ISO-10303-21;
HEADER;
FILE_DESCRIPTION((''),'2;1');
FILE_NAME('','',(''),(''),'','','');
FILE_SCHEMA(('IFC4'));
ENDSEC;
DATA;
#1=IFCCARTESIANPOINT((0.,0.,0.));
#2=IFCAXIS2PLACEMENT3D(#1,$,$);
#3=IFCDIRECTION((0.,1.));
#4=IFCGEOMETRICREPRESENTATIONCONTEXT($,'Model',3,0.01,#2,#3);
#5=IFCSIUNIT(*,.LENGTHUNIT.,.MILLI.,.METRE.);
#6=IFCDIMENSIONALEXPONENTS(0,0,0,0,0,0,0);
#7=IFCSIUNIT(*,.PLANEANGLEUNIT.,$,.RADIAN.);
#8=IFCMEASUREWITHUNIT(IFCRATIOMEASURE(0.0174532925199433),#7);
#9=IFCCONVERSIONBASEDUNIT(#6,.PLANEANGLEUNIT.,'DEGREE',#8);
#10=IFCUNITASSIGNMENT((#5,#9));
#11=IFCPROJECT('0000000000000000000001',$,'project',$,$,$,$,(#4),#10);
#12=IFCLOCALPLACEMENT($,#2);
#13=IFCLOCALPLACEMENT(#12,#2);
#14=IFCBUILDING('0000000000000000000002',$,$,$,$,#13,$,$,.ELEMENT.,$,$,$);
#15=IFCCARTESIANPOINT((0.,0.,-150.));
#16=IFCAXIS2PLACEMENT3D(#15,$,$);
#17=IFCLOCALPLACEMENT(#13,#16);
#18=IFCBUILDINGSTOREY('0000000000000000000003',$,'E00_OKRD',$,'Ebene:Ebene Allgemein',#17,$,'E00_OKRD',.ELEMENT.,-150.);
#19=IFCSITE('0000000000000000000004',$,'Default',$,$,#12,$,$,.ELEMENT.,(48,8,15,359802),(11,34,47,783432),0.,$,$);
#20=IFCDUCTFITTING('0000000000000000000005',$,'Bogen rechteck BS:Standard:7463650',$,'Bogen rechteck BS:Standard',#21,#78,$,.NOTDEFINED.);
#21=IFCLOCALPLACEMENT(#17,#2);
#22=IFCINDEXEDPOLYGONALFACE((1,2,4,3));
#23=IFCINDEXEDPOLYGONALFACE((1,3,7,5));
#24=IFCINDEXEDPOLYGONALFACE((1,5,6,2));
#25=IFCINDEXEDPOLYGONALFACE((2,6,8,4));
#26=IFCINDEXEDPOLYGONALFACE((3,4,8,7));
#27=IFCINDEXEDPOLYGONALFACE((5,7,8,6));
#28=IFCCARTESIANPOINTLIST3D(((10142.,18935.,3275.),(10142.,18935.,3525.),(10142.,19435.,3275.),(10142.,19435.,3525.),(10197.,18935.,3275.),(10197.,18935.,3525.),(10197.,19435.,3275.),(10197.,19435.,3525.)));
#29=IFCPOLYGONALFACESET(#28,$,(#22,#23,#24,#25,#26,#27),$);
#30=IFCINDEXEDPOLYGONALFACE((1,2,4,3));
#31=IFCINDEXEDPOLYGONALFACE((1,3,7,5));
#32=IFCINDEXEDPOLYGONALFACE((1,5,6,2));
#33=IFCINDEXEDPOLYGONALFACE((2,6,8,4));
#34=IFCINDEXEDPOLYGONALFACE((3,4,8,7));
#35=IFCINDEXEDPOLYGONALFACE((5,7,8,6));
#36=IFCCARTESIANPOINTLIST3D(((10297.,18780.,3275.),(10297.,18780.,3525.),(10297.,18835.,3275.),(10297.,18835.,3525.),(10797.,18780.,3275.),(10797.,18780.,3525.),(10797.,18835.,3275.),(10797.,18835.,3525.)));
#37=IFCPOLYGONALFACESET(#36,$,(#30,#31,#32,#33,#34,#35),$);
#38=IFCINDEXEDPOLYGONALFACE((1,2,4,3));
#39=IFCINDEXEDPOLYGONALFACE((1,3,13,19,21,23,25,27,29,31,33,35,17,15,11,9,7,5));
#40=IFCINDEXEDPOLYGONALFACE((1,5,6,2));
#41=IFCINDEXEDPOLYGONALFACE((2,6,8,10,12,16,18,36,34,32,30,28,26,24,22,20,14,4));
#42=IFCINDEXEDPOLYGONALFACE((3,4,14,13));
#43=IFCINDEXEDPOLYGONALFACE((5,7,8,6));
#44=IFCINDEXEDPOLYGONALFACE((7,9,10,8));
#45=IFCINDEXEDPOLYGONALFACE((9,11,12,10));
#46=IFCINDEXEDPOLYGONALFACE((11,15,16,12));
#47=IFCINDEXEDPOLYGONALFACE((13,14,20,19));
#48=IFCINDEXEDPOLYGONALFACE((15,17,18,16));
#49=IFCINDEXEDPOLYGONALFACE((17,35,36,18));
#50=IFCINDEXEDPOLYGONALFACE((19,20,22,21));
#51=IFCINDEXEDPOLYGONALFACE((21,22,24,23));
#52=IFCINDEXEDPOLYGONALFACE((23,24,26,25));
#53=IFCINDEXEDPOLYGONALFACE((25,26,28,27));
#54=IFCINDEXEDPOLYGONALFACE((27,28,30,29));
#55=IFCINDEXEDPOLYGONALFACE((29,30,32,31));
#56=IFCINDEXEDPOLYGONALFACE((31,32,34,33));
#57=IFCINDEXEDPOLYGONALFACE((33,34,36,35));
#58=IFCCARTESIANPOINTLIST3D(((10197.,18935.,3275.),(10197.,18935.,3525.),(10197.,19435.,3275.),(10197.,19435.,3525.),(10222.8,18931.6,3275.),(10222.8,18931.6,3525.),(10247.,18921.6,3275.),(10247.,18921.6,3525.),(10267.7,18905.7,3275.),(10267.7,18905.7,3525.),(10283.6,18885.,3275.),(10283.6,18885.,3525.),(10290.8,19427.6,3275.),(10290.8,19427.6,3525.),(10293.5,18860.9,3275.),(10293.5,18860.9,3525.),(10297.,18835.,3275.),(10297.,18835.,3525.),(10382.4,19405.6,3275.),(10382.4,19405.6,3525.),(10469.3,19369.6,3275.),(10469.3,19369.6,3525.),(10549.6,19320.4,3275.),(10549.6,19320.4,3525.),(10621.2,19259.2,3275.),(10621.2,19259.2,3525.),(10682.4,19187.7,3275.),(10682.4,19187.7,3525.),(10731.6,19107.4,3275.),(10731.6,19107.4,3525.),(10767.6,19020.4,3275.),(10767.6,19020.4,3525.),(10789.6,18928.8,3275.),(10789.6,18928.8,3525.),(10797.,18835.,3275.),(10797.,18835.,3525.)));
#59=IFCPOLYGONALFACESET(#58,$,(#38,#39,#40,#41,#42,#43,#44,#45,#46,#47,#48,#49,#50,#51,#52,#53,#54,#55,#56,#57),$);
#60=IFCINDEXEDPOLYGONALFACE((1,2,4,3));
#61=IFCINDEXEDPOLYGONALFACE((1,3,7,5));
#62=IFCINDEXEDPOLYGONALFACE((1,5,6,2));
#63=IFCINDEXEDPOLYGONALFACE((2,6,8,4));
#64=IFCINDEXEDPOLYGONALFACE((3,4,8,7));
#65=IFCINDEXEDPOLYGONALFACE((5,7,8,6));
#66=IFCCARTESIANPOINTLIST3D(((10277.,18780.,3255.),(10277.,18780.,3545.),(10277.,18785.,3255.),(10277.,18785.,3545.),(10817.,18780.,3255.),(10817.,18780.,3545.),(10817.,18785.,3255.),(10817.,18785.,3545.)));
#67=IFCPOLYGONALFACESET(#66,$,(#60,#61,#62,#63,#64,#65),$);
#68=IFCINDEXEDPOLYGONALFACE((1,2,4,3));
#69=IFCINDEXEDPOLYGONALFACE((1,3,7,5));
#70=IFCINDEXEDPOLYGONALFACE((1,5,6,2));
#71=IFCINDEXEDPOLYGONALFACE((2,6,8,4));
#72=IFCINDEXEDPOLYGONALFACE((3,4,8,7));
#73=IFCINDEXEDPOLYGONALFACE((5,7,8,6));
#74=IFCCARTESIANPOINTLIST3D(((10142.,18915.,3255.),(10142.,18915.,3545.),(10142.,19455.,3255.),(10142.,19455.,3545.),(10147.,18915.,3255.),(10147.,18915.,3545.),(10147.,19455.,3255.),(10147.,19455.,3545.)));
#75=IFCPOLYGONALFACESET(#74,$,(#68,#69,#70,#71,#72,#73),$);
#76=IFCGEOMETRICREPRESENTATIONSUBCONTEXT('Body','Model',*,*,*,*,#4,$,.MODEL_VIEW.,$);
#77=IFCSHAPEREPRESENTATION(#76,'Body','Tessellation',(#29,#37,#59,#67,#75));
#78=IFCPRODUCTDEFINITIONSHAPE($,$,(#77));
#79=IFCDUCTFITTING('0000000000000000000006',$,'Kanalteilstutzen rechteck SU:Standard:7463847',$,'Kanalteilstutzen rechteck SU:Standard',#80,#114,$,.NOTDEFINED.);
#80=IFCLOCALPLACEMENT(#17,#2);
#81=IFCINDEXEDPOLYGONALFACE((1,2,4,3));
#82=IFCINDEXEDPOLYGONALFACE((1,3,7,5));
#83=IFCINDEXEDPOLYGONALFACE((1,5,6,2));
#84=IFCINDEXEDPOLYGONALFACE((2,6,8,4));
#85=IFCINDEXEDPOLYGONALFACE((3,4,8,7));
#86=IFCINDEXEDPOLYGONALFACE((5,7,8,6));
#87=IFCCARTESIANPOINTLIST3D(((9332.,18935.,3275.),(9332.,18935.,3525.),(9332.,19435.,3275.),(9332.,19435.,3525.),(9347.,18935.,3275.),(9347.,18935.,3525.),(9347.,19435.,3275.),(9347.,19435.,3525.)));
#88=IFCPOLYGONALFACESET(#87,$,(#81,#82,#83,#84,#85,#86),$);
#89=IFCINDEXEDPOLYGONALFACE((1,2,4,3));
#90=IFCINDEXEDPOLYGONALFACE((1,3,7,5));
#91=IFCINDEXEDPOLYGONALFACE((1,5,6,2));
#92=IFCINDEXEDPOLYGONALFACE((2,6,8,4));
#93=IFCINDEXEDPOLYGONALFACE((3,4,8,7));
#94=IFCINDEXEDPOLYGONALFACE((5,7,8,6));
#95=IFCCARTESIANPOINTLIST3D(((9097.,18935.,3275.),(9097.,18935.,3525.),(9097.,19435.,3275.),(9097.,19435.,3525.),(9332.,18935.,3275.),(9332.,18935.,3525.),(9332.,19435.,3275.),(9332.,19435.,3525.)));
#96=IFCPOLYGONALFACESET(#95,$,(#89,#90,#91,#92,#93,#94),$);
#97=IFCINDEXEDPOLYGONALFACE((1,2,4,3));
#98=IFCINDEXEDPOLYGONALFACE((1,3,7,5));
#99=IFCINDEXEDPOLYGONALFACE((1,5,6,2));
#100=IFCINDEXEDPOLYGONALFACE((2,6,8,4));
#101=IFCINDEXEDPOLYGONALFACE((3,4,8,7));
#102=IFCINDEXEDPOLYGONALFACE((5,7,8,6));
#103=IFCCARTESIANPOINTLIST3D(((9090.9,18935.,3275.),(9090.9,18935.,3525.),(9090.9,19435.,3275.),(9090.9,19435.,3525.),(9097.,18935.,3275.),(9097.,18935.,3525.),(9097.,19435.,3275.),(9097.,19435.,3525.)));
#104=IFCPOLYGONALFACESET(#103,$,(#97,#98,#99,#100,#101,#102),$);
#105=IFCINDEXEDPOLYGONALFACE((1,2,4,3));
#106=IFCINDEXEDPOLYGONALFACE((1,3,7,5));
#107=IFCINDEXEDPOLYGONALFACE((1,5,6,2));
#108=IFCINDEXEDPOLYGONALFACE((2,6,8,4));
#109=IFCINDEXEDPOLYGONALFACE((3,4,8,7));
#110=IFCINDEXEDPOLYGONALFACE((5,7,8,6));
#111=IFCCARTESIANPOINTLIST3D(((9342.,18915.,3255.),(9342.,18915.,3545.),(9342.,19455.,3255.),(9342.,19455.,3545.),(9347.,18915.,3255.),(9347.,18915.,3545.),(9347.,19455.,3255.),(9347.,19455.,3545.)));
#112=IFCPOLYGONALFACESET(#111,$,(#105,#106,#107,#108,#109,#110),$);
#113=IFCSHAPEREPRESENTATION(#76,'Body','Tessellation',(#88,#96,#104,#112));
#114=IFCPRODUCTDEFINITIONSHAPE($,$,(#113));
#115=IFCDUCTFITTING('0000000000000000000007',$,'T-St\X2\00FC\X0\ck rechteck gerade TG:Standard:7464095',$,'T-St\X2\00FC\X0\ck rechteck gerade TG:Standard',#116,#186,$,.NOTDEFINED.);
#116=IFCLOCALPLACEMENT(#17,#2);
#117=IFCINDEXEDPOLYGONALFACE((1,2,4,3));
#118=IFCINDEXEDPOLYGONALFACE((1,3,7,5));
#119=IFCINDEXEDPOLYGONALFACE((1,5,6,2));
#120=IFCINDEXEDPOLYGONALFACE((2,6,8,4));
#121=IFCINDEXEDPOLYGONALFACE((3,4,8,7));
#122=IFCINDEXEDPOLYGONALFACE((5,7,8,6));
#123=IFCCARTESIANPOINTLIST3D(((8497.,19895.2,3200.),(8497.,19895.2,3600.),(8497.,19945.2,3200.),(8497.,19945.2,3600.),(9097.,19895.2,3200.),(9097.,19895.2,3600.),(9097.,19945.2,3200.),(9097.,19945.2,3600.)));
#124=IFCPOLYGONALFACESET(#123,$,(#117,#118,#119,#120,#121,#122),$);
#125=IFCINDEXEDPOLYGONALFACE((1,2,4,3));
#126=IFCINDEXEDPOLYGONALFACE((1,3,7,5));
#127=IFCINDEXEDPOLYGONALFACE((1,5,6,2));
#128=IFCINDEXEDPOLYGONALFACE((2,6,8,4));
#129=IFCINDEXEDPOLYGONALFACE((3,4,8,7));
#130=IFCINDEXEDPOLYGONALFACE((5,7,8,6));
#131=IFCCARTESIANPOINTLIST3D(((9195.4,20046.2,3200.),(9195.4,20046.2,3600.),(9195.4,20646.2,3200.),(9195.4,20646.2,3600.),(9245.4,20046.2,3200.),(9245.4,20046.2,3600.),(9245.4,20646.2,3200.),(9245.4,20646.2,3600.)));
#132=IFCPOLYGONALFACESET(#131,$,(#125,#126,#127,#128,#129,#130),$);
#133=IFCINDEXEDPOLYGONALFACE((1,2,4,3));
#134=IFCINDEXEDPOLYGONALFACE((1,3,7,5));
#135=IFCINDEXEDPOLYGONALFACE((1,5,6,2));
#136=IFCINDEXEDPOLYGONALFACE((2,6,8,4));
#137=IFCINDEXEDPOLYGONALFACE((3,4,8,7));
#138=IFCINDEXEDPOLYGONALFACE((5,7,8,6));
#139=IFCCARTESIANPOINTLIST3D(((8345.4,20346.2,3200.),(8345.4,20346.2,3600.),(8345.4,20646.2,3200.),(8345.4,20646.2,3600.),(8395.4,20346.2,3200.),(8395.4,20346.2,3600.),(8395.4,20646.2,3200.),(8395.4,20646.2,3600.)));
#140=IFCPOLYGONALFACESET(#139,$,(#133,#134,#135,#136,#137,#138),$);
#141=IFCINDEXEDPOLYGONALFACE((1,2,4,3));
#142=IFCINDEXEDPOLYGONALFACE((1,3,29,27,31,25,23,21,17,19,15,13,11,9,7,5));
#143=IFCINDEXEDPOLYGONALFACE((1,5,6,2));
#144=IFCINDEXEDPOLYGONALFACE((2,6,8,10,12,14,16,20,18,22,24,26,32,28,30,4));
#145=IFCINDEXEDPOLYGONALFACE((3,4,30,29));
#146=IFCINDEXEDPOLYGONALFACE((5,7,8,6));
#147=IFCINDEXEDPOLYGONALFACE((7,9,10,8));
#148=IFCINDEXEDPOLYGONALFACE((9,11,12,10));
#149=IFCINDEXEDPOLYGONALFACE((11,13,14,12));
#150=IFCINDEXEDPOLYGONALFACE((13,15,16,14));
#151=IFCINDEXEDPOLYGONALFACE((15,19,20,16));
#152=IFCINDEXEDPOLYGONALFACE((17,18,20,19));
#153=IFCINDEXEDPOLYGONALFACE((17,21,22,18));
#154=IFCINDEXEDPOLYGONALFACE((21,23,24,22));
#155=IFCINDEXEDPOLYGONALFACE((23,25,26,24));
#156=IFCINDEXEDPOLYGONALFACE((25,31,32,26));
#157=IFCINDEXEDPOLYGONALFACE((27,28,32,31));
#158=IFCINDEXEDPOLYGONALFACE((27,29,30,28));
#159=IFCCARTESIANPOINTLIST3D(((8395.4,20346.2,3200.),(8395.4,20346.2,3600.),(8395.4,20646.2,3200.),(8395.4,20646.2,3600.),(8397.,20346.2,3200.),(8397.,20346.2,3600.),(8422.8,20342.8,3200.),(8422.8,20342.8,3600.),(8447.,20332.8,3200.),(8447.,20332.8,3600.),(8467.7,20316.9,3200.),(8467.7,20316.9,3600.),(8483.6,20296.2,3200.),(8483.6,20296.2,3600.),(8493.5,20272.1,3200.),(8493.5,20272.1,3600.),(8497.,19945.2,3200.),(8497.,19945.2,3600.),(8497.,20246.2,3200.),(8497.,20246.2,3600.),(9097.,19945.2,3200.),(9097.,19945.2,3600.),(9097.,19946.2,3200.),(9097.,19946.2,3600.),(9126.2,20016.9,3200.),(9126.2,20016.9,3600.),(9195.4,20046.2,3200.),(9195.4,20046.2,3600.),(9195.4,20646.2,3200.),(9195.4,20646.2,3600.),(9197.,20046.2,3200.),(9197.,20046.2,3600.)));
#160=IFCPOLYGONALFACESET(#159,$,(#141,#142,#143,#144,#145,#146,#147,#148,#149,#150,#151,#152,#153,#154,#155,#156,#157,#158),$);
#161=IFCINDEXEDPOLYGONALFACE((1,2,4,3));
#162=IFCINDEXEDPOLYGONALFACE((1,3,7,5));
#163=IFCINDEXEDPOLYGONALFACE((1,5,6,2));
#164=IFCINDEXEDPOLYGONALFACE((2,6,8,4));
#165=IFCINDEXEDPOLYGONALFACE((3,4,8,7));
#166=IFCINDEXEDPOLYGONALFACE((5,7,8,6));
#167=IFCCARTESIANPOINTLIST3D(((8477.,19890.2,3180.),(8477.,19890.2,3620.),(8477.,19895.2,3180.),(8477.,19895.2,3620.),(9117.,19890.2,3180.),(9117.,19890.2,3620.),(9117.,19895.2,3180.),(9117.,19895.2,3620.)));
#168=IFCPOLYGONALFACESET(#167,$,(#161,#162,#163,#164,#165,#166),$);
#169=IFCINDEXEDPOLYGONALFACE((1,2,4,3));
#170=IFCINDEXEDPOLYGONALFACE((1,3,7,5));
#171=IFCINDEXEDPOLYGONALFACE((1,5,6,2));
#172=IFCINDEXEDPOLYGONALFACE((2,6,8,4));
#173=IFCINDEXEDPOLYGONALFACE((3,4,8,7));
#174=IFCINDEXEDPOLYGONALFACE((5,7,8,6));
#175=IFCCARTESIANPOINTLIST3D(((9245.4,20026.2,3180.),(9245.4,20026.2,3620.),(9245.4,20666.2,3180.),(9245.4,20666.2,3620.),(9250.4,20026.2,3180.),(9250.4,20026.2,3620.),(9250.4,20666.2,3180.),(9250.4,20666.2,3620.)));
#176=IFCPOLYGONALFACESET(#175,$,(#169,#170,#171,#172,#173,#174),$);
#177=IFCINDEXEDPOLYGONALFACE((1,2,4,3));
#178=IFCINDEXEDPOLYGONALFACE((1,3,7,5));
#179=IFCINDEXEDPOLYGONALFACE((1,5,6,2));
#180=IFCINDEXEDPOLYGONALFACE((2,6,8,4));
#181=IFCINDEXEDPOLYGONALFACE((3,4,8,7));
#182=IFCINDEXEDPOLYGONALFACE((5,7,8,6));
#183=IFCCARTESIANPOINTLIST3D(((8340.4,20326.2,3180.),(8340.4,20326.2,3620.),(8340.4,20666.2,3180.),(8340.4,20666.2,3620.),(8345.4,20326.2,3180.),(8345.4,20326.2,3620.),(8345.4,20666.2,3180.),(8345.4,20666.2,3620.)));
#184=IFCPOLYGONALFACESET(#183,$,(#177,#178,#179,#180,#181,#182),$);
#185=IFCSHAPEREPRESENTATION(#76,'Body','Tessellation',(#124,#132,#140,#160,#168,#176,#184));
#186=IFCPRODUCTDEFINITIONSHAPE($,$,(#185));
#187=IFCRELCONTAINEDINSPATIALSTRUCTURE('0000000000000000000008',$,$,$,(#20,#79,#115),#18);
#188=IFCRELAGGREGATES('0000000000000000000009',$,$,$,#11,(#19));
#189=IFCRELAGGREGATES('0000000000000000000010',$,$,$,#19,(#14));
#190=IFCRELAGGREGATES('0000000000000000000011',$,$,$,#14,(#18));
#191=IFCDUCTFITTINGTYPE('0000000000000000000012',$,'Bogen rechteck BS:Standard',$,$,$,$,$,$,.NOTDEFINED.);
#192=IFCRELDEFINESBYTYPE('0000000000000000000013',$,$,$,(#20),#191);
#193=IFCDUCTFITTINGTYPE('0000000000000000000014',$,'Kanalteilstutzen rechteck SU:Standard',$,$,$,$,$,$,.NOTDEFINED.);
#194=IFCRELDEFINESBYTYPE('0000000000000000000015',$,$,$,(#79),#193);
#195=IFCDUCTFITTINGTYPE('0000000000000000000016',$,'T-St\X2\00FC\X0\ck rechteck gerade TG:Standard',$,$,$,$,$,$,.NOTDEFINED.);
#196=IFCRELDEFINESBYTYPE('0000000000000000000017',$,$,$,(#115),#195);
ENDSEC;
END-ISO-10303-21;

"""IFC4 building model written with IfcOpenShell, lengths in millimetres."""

from ifc_helpers import new_model, entity, si_unit, converted_unit, direction, frame, frame_2d, origin, origin_2d_with_axis, place, context, subcontext, project, spatial, polyline, circle_curve, parameter, trimmed, segment, composite_curve, rectangle, outline, extrude, source, transform, mapped, type_object, type_shapes, element, save


model = new_model("IFC4")

# Units and contexts
model_context = context("Model", 3, precision=0.01, world=origin(), true_north=direction((0.0, 1.0)))
body_context = subcontext(model_context, "Body", "Model", "MODEL_VIEW")
ifc_project = project(units=[si_unit("LENGTHUNIT", "METRE", prefix="MILLI"), converted_unit("PLANEANGLEUNIT", "DEGREE", entity("IfcRatioMeasure", 0.0174532925199433), si_unit("PLANEANGLEUNIT", "RADIAN"), dimensions=[0, 0, 0, 0, 0, 0, 0])], contexts=[model_context])

# Site, building, storey
site_placement = place(None, origin())
site = spatial("IfcSite", under=ifc_project, at=site_placement, Name="Default", CompositionType="ELEMENT", RefLatitude=(48, 8, 15, 359802), RefLongitude=(11, 34, 47, 783432), RefElevation=0.0)
building_placement = place(site_placement, origin())
building = spatial("IfcBuilding", under=site, at=building_placement, CompositionType="ELEMENT")
storey_placement = place(building_placement, frame((0.0, 0.0, -150.0)))
storey = spatial("IfcBuildingStorey", under=building, at=storey_placement, Name="E00_OKRD", ObjectType="Ebene:Ebene Allgemein", LongName="E00_OKRD", CompositionType="ELEMENT", Elevation=-150.0)

# Duct fittings
duct_fitting_type_1 = type_object("IfcDuctFittingType", Name="Bogen rechteck BS:Standard", PredefinedType="NOTDEFINED")
shared_shape_1 = source(origin(), body_context, "Body", "SweptSolid", [
    extrude(rectangle(XDim=55.0, YDim=500.0, at=frame_2d((0.0, 0.0), x_axis=(1.0, 0.0))), frame((0.0, 377.5, -125.0), z_axis=(0.0, 0.0, 1.0), x_axis=(0.0, 1.0, 0.0)), (0.0, 0.0, 1.0), 250.0),
    extrude(rectangle(XDim=500.0, YDim=55.0, at=frame_2d((0.0, 0.0), x_axis=(1.0, 0.0))), frame((-377.5, 0.0, -125.0), z_axis=(0.0, 0.0, 1.0), x_axis=(0.0, -1.0, 0.0)), (0.0, 0.0, 1.0), 250.0),
    extrude(outline(composite_curve([segment(polyline([(-425.0, -175.0), (75.0, -175.0)]), True, "CONTINUOUS"), segment(trimmed(circle_curve(frame_2d((175.0, -175.0), x_axis=(0.0, 1.0)), 100.0), [parameter(0.0)], [parameter(90.0)], True, "PARAMETER"), False, "CONTINUOUS"), segment(polyline([(175.0, -75.0), (175.0, 425.0)]), True, "CONTINUOUS"), segment(trimmed(circle_curve(frame_2d((175.0, -175.0), x_axis=(0.0, 1.0)), 600.0), [parameter(0.0)], [parameter(90.0)], True, "PARAMETER"), True, "CONTINUOUS")], self_intersect=False)), frame((-175.0, 175.0, -125.0), z_axis=(0.0, 0.0, 1.0), x_axis=(-1.0, 0.0, 0.0)), (0.0, 0.0, 1.0), 250.0),
    extrude(rectangle(XDim=5.0, YDim=540.0, at=frame_2d((0.0, 0.0), x_axis=(1.0, 0.0))), frame((-402.5, 0.0, -145.0)), (0.0, 0.0, 1.0), 290.0),
    extrude(rectangle(XDim=5.0, YDim=540.0, at=origin_2d_with_axis()), frame((0.0, 402.5, -145.0), z_axis=(0.0, 0.0, 1.0), x_axis=(0.0, 1.0, 0.0)), (0.0, 0.0, 1.0), 290.0),
])
type_shapes(duct_fitting_type_1, [shared_shape_1])
duct_fitting_1_placement = place(storey_placement, frame((10547.0, 19185.0, 3400.0), z_axis=(0.0, 0.0, 1.0), x_axis=(0.0, 1.0, 0.0)))
element("IfcDuctFitting", 1, at=duct_fitting_1_placement, inside=storey, type_object=duct_fitting_type_1, Name="Bogen rechteck BS:Standard:7463650", ObjectType="Bogen rechteck BS:Standard", PredefinedType="NOTDEFINED", context=body_context, shape_type="MappedRepresentation", body=[
    mapped(shared_shape_1, transform((0.0, 0.0, 0.0), scale=1.0)),
])
duct_fitting_type_2 = type_object("IfcDuctFittingType", Name="Kanalteilstutzen rechteck SU:Standard", PredefinedType="NOTDEFINED")
shared_shape_2 = source(origin(), body_context, "Body", "SweptSolid", [
    extrude(rectangle(XDim=15.0, YDim=500.0, at=frame_2d((0.0, 0.0), x_axis=(1.0, 0.0))), frame((242.5, 0.0, -125.0)), (0.0, 0.0, 1.0), 250.0),
    extrude(rectangle(XDim=235.0, YDim=500.0, at=frame_2d((0.0, 0.0), x_axis=(1.0, 0.0))), frame((117.5, 0.0, -125.0)), (0.0, 0.0, 1.0), 250.0),
    extrude(rectangle(XDim=6.1, YDim=500.0, at=frame_2d((0.0, 0.0), x_axis=(1.0, 0.0))), frame((-3.0, 0.0, -125.0)), (0.0, 0.0, 1.0), 250.0),
    extrude(rectangle(XDim=5.0, YDim=540.0, at=frame_2d((0.0, 0.0), x_axis=(1.0, 0.0))), frame((247.5, 0.0, -145.0)), (0.0, 0.0, 1.0), 290.0),
])
type_shapes(duct_fitting_type_2, [shared_shape_2])
duct_fitting_2_placement = place(storey_placement, frame((9097.0, 19185.0, 3400.0), z_axis=(0.0, 0.0, -1.0), x_axis=(1.0, 0.0, 0.0)))
element("IfcDuctFitting", 2, at=duct_fitting_2_placement, inside=storey, type_object=duct_fitting_type_2, Name="Kanalteilstutzen rechteck SU:Standard:7463847", ObjectType="Kanalteilstutzen rechteck SU:Standard", PredefinedType="NOTDEFINED", context=body_context, shape_type="MappedRepresentation", body=[
    mapped(shared_shape_2, transform((0.0, 0.0, 0.0), scale=1.0)),
])
duct_fitting_type_3 = type_object("IfcDuctFittingType", Name="T-Stück rechteck gerade TG:Standard", PredefinedType="NOTDEFINED")
shared_shape_3 = source(origin(), body_context, "Body", "SweptSolid", [
    extrude(rectangle(XDim=50.0, YDim=600.0, at=frame_2d((0.0, 0.0), x_axis=(1.0, 0.0))), frame((0.0, -501.0, -200.0), z_axis=(0.0, 0.0, 1.0), x_axis=(0.0, -1.0, 0.0)), (0.0, 0.0, 1.0), 400.0),
    extrude(rectangle(XDim=50.0, YDim=600.0, at=frame_2d((0.0, 0.0), x_axis=(1.0, 0.0))), frame((423.4, -75.0, -200.0), z_axis=(0.0, 0.0, 1.0), x_axis=(-1.0, 0.0, 0.0)), (0.0, 0.0, 1.0), 400.0),
    extrude(rectangle(XDim=50.0, YDim=300.0, at=origin_2d_with_axis()), frame((-426.6, 75.0, -200.0)), (0.0, 0.0, 1.0), 400.0),
    extrude(outline(composite_curve([segment(trimmed(circle_curve(frame_2d((-400.6, -269.8), x_axis=(-1.0, 0.0)), 100.0), [parameter(180.0)], [parameter(270.0)], True, "PARAMETER"), False, "CONTINUOUS"), segment(polyline([(-300.6, -269.8), (-300.6, -270.8)]), True, "CONTINUOUS"), segment(polyline([(-300.6, -270.8), (299.4, -270.8)]), True, "CONTINUOUS"), segment(polyline([(299.4, -270.8), (299.4, 30.2)]), True, "CONTINUOUS"), segment(trimmed(circle_curve(frame_2d((399.4, 30.2), x_axis=(-1.0, 0.0)), 100.0), [parameter(270.0)], [parameter(0.0)], True, "PARAMETER"), False, "CONTINUOUS"), segment(polyline([(399.4, 130.2), (401.0, 130.2)]), True, "CONTINUOUS"), segment(polyline([(401.0, 130.2), (401.0, 430.2)]), True, "CONTINUOUS"), segment(polyline([(401.0, 430.2), (-399.0, 430.2)]), True, "CONTINUOUS"), segment(polyline([(-399.0, 430.2), (-399.0, -169.8)]), True, "CONTINUOUS"), segment(polyline([(-399.0, -169.8), (-400.6, -169.8)]), True, "CONTINUOUS")], self_intersect=False)), frame((-0.6, -205.2, -200.0), z_axis=(0.0, 0.0, -1.0), x_axis=(-1.0, 0.0, 0.0)), (0.0, 0.0, -1.0), 400.0),
    extrude(rectangle(XDim=5.0, YDim=640.0, at=origin_2d_with_axis()), frame((0.0, -528.5, -220.0), z_axis=(0.0, 0.0, 1.0), x_axis=(0.0, 1.0, 0.0)), (0.0, 0.0, 1.0), 440.0),
    extrude(rectangle(XDim=5.0, YDim=640.0, at=origin_2d_with_axis()), frame((450.9, -75.0, -220.0), z_axis=(0.0, 0.0, 1.0), x_axis=(-1.0, 0.0, 0.0)), (0.0, 0.0, 1.0), 440.0),
    extrude(rectangle(XDim=5.0, YDim=340.0, at=frame_2d((0.0, 0.0), x_axis=(1.0, 0.0))), frame((-454.1, 75.0, -220.0), z_axis=(0.0, 0.0, 1.0), x_axis=(-1.0, 0.0, 0.0)), (0.0, 0.0, 1.0), 440.0),
])
type_shapes(duct_fitting_type_3, [shared_shape_3])
duct_fitting_3_placement = place(storey_placement, frame((8797.0, 20421.2, 3400.0)))
element("IfcDuctFitting", 3, at=duct_fitting_3_placement, inside=storey, type_object=duct_fitting_type_3, Name="T-Stück rechteck gerade TG:Standard:7464095", ObjectType="T-Stück rechteck gerade TG:Standard", PredefinedType="NOTDEFINED", context=body_context, shape_type="MappedRepresentation", body=[
    mapped(shared_shape_3, transform((0.0, 0.0, 0.0), scale=1.0)),
])

save(model, "model.ifc")
